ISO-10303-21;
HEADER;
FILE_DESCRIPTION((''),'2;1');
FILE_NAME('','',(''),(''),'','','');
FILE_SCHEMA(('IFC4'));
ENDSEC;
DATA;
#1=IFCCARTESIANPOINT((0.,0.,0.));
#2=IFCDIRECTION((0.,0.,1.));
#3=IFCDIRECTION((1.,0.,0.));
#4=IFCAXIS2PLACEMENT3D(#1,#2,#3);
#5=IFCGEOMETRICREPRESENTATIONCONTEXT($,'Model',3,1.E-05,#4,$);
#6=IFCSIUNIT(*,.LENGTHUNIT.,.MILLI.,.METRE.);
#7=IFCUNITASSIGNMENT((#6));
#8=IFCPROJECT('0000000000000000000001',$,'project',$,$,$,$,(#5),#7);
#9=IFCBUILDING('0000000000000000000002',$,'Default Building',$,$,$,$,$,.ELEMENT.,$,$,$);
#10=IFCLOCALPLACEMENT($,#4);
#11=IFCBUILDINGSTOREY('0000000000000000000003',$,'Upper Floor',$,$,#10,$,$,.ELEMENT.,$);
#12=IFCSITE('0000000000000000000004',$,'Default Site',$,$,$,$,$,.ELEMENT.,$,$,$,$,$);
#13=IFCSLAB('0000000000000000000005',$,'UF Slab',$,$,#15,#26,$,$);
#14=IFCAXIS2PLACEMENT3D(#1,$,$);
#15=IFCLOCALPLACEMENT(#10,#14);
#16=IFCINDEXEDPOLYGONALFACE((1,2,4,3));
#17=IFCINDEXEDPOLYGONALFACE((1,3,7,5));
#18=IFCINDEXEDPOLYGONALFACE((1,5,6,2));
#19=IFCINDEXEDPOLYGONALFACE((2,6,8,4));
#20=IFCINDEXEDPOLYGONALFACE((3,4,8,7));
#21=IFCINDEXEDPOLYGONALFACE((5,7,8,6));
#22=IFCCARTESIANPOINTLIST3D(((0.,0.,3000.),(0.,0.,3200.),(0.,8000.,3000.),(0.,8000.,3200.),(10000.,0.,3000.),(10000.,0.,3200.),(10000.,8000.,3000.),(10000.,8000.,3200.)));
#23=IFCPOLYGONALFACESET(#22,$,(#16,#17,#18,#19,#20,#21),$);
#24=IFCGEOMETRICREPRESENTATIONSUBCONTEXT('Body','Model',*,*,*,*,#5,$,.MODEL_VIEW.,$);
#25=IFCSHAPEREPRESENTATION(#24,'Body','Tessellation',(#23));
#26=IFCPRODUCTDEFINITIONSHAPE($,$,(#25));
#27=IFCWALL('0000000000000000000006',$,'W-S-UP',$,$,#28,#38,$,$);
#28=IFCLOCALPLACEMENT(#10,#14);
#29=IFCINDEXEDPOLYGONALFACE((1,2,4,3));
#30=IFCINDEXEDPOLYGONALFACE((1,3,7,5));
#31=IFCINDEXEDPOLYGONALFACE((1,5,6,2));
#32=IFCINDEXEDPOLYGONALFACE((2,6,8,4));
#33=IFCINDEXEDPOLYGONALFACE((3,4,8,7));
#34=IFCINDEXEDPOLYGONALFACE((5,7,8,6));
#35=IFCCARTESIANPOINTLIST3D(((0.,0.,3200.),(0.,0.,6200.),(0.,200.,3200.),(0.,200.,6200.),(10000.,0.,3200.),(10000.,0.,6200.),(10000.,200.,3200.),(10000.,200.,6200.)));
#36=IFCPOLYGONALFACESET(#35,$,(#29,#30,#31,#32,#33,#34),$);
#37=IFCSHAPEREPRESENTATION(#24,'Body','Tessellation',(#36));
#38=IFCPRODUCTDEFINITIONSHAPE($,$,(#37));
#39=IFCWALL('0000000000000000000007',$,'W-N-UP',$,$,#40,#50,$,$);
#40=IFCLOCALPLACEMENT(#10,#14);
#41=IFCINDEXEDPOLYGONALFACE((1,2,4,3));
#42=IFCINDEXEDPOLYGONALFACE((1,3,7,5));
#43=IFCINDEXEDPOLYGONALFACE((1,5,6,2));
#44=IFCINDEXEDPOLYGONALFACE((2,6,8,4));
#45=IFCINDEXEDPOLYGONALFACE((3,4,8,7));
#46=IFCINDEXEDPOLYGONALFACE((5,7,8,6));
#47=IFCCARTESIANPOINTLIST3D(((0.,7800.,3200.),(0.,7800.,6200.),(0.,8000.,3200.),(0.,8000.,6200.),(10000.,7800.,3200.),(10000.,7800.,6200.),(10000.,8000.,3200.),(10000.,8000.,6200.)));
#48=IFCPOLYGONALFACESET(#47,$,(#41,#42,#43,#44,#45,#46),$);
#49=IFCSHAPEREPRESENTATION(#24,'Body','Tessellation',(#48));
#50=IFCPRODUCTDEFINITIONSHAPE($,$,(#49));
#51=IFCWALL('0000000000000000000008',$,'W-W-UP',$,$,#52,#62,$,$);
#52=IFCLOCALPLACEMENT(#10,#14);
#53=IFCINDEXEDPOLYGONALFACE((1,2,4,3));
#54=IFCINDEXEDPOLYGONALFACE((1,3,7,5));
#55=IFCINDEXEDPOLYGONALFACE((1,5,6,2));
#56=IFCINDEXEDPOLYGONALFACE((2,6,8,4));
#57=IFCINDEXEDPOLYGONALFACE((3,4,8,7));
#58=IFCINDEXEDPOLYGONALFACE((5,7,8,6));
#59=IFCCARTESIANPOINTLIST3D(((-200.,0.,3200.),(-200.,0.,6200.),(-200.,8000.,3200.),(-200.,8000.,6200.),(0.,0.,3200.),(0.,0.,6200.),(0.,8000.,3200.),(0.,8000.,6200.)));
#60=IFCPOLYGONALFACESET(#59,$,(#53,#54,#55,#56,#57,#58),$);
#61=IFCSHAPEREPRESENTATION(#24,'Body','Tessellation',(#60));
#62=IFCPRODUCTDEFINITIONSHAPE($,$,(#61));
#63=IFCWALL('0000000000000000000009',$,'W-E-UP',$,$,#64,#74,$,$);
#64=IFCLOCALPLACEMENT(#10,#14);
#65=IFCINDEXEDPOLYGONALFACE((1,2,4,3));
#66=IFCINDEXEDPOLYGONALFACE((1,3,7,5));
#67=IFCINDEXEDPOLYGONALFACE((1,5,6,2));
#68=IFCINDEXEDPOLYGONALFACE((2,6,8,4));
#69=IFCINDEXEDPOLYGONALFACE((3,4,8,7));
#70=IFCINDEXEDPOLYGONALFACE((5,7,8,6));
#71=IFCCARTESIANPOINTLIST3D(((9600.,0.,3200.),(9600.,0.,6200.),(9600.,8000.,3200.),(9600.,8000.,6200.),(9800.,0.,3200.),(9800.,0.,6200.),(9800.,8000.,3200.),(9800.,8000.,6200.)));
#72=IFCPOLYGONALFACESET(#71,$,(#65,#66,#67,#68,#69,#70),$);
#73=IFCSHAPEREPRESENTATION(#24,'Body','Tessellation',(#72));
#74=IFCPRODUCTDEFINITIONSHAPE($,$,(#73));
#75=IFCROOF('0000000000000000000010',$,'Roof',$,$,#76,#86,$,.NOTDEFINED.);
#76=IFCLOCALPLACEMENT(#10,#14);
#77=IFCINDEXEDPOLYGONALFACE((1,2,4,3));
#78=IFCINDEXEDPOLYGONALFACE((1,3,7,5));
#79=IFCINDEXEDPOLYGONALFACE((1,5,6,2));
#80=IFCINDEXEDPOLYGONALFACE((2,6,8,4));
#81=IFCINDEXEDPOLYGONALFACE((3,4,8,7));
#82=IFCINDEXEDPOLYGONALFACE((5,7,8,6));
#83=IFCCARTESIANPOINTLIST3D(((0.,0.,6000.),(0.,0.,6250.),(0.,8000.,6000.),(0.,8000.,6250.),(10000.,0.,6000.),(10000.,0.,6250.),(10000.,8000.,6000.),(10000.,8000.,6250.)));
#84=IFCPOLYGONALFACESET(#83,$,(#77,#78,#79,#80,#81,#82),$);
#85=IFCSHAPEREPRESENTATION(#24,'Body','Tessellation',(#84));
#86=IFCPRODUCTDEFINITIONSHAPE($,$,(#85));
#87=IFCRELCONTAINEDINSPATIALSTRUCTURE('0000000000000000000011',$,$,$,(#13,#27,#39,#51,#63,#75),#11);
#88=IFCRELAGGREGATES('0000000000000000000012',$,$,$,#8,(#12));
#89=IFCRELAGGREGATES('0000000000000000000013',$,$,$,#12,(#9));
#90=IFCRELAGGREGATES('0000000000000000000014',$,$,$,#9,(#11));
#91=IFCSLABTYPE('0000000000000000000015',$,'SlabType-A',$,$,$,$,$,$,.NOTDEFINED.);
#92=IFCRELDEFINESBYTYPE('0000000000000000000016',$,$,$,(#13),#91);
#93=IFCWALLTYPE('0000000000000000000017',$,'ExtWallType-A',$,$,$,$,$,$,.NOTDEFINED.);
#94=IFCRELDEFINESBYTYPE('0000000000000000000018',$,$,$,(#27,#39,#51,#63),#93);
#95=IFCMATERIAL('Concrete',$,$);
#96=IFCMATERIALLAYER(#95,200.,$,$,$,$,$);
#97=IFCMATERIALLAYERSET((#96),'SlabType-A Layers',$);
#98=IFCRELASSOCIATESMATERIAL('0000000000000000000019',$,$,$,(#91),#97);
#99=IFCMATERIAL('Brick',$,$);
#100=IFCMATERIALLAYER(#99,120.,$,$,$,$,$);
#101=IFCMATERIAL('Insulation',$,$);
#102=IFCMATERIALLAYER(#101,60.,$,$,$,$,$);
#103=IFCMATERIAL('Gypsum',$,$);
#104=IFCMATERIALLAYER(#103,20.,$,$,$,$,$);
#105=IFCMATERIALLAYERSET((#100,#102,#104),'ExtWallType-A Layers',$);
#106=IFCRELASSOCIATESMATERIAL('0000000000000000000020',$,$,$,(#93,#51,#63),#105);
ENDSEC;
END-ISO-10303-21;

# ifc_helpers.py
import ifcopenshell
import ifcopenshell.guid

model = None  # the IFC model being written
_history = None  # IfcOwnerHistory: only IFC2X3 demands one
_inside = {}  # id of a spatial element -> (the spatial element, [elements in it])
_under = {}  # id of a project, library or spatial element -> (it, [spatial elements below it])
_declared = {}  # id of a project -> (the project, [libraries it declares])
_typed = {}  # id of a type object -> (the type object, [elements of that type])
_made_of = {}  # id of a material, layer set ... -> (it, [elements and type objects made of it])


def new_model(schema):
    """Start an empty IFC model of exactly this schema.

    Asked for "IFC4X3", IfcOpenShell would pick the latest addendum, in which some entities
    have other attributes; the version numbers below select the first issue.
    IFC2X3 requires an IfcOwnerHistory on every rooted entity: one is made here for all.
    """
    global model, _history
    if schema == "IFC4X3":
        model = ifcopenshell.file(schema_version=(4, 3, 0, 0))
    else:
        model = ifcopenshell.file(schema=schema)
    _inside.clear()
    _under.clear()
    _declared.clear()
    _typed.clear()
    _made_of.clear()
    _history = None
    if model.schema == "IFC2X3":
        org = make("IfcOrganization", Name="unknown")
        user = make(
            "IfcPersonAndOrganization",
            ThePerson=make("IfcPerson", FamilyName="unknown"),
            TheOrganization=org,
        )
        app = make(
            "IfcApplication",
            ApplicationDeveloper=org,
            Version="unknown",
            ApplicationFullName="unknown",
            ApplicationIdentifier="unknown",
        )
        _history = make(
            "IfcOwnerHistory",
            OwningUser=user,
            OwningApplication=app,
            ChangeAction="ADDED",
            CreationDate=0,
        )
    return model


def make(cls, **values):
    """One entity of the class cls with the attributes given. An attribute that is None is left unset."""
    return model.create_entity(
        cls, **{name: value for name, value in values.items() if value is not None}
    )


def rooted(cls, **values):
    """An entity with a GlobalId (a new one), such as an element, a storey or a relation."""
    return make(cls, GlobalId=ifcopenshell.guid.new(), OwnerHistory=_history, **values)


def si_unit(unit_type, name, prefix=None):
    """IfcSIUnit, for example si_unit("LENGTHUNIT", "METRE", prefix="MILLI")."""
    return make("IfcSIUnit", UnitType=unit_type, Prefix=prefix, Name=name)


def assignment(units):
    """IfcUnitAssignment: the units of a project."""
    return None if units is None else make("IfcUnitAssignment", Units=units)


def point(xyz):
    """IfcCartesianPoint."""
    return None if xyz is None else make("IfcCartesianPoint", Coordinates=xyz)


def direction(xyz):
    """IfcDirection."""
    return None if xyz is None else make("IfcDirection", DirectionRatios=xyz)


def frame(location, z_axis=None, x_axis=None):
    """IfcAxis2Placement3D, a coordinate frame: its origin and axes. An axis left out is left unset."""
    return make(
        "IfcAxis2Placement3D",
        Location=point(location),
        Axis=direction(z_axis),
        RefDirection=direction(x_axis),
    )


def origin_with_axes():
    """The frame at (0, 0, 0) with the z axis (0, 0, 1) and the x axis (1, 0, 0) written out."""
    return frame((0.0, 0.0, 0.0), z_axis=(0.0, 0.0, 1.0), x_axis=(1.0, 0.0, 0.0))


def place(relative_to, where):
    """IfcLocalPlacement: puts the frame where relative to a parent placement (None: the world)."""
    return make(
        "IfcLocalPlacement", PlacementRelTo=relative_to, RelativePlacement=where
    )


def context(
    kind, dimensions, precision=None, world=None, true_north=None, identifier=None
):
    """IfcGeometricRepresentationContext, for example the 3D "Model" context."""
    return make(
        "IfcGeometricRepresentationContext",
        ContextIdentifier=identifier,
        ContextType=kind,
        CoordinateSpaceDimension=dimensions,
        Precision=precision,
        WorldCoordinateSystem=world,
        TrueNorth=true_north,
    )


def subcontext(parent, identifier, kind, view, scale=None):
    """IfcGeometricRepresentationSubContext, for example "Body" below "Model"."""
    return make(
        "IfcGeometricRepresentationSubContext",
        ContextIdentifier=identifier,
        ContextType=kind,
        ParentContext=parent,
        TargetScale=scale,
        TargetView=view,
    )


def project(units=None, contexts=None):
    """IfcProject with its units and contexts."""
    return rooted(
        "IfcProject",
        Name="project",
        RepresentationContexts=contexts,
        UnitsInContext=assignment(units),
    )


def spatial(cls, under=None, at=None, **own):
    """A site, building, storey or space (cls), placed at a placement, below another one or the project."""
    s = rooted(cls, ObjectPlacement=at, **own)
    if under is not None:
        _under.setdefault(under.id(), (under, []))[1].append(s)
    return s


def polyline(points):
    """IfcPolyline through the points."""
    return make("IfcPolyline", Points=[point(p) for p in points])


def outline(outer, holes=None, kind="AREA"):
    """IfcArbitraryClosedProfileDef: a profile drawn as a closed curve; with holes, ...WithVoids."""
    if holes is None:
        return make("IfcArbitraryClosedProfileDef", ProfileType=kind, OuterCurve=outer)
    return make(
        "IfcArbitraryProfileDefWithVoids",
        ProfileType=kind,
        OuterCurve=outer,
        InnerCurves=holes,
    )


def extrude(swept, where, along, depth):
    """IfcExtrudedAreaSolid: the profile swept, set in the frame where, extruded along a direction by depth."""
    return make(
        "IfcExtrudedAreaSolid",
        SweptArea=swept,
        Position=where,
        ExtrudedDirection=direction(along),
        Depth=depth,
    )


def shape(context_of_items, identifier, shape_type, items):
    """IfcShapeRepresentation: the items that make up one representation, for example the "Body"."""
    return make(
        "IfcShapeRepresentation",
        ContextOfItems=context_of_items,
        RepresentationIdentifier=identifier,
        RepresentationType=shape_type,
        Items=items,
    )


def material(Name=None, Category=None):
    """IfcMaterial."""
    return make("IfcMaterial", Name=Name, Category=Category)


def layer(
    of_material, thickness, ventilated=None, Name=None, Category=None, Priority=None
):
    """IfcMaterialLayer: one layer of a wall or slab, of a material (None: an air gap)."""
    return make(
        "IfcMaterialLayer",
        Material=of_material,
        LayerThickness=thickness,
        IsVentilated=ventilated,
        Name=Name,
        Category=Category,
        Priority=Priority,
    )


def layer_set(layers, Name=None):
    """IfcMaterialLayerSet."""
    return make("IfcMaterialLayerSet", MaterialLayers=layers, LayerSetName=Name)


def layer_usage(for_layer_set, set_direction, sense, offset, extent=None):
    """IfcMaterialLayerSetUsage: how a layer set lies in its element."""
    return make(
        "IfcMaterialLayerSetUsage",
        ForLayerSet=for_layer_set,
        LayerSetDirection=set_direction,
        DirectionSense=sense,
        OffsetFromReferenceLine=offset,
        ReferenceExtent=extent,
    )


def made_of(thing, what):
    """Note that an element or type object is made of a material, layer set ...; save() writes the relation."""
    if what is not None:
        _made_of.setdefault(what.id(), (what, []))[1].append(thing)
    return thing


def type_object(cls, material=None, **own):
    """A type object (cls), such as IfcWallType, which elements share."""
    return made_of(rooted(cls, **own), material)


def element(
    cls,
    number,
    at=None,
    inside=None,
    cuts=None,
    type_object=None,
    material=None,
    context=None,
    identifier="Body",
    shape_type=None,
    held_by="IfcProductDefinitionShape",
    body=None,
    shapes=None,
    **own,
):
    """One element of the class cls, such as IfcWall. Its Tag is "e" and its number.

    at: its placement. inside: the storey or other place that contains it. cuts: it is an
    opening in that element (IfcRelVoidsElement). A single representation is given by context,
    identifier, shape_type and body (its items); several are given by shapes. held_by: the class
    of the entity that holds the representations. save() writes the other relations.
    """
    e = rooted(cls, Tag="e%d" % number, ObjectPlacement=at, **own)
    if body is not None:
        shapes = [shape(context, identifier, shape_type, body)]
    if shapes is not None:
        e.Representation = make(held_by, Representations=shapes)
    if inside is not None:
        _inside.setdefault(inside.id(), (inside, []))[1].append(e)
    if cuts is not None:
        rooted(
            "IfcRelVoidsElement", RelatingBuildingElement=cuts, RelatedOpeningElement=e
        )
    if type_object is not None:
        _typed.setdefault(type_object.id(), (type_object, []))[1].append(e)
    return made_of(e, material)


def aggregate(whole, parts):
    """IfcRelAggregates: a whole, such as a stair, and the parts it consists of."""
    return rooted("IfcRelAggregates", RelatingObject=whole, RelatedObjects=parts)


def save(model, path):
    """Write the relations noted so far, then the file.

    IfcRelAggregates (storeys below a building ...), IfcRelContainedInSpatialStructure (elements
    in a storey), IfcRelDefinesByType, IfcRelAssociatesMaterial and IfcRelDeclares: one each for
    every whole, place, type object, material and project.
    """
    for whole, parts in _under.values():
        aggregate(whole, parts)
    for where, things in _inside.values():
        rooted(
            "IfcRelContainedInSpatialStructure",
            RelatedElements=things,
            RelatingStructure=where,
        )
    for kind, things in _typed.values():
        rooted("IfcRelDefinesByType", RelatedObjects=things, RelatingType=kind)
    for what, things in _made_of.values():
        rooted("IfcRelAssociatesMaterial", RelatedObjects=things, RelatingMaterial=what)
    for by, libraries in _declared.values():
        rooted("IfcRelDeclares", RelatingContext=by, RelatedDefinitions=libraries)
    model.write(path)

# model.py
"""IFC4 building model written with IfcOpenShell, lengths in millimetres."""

from ifc_helpers import new_model, si_unit, frame, origin_with_axes, place, context, subcontext, project, spatial, polyline, outline, extrude, material, layer, layer_set, layer_usage, type_object, element, save


model = new_model("IFC4")

# Units and contexts
model_context = context("Model", 3, precision=1e-05, world=origin_with_axes())
body_context = subcontext(model_context, "Body", "Model", "MODEL_VIEW")
ifc_project = project(units=[si_unit("LENGTHUNIT", "METRE", prefix="MILLI")], contexts=[model_context])

# Site, building, storey
site = spatial("IfcSite", under=ifc_project, Name="Default Site", CompositionType="ELEMENT")
building = spatial("IfcBuilding", under=site, Name="Default Building", CompositionType="ELEMENT")
storey_placement = place(None, origin_with_axes())
storey = spatial("IfcBuildingStorey", under=building, at=storey_placement, Name="Upper Floor", CompositionType="ELEMENT")

# Slab
ifc_material_1 = material(Name="Concrete")
ifc_layer_1 = layer(ifc_material_1, 200.0)
ifc_layer_set_1 = layer_set([ifc_layer_1], Name="SlabType-A Layers")
slab_type = type_object("IfcSlabType", Name="SlabType-A", PredefinedType="NOTDEFINED", material=ifc_layer_set_1)
slab_placement = place(storey_placement, frame((0.0, 0.0, 3000.0), z_axis=(0.0, 0.0, 1.0), x_axis=(1.0, 0.0, 0.0)))
element("IfcSlab", 1, at=slab_placement, inside=storey, type_object=slab_type, Name="UF Slab", context=body_context, shape_type="SweptSolid", body=[
    extrude(outline(polyline([(0.0, 0.0), (10000.0, 0.0), (10000.0, 8000.0), (0.0, 8000.0), (0.0, 0.0)])), origin_with_axes(), (0.0, 0.0, 1.0), 200.0),
])

# Walls
ifc_material_2 = material(Name="Brick")
ifc_layer_2 = layer(ifc_material_2, 120.0)
ifc_material_3 = material(Name="Insulation")
ifc_layer_3 = layer(ifc_material_3, 60.0)
ifc_material_4 = material(Name="Gypsum")
ifc_layer_4 = layer(ifc_material_4, 20.0)
ifc_layer_set_2 = layer_set([ifc_layer_2, ifc_layer_3, ifc_layer_4], Name="ExtWallType-A Layers")
wall_type = type_object("IfcWallType", Name="ExtWallType-A", PredefinedType="NOTDEFINED", material=ifc_layer_set_2)
wall_1_placement = place(storey_placement, frame((0.0, 0.0, 3200.0), z_axis=(0.0, 0.0, 1.0), x_axis=(1.0, 0.0, 0.0)))
element("IfcWall", 2, at=wall_1_placement, inside=storey, type_object=wall_type, Name="W-S-UP", context=body_context, shape_type="SweptSolid", body=[
    extrude(outline(polyline([(0.0, 0.0), (10000.0, 0.0), (10000.0, 200.0), (0.0, 200.0), (0.0, 0.0)])), origin_with_axes(), (0.0, 0.0, 1.0), 3000.0),
])
wall_2_placement = place(storey_placement, frame((0.0, 0.0, 3200.0), z_axis=(0.0, 0.0, 1.0), x_axis=(1.0, 0.0, 0.0)))
element("IfcWall", 3, at=wall_2_placement, inside=storey, type_object=wall_type, Name="W-N-UP", context=body_context, shape_type="SweptSolid", body=[
    extrude(outline(polyline([(0.0, 7800.0), (10000.0, 7800.0), (10000.0, 8000.0), (0.0, 8000.0), (0.0, 7800.0)])), origin_with_axes(), (0.0, 0.0, 1.0), 3000.0),
])
ifc_layer_usage = layer_usage(ifc_layer_set_2, "AXIS2", "POSITIVE", 0.0)
wall_3_placement = place(storey_placement, frame((0.0, 0.0, 3200.0), z_axis=(0.0, 0.0, 1.0), x_axis=(1.0, 0.0, 0.0)))
element("IfcWall", 4, at=wall_3_placement, inside=storey, type_object=wall_type, material=ifc_layer_usage, Name="W-W-UP", context=body_context, shape_type="SweptSolid", body=[
    extrude(outline(polyline([(0.0, 0.0), (0.0, 8000.0), (-200.0, 8000.0), (-200.0, 0.0), (0.0, 0.0)])), origin_with_axes(), (0.0, 0.0, 1.0), 3000.0),
])
wall_4_placement = place(storey_placement, frame((0.0, 0.0, 3200.0), z_axis=(0.0, 0.0, 1.0), x_axis=(1.0, 0.0, 0.0)))
element("IfcWall", 5, at=wall_4_placement, inside=storey, type_object=wall_type, material=ifc_layer_usage, Name="W-E-UP", context=body_context, shape_type="SweptSolid", body=[
    extrude(outline(polyline([(9800.0, 0.0), (9800.0, 8000.0), (9600.0, 8000.0), (9600.0, 0.0), (9800.0, 0.0)])), origin_with_axes(), (0.0, 0.0, 1.0), 3000.0),
])

# Roof
roof_placement = place(storey_placement, frame((0.0, 0.0, 6000.0), z_axis=(0.0, 0.0, 1.0), x_axis=(1.0, 0.0, 0.0)))
element("IfcRoof", 6, at=roof_placement, inside=storey, Name="Roof", PredefinedType="NOTDEFINED", context=body_context, shape_type="SweptSolid", body=[
    extrude(outline(polyline([(0.0, 0.0), (10000.0, 0.0), (10000.0, 8000.0), (0.0, 8000.0), (0.0, 0.0)])), origin_with_axes(), (0.0, 0.0, 1.0), 250.0),
])

save(model, "model.ifc")
